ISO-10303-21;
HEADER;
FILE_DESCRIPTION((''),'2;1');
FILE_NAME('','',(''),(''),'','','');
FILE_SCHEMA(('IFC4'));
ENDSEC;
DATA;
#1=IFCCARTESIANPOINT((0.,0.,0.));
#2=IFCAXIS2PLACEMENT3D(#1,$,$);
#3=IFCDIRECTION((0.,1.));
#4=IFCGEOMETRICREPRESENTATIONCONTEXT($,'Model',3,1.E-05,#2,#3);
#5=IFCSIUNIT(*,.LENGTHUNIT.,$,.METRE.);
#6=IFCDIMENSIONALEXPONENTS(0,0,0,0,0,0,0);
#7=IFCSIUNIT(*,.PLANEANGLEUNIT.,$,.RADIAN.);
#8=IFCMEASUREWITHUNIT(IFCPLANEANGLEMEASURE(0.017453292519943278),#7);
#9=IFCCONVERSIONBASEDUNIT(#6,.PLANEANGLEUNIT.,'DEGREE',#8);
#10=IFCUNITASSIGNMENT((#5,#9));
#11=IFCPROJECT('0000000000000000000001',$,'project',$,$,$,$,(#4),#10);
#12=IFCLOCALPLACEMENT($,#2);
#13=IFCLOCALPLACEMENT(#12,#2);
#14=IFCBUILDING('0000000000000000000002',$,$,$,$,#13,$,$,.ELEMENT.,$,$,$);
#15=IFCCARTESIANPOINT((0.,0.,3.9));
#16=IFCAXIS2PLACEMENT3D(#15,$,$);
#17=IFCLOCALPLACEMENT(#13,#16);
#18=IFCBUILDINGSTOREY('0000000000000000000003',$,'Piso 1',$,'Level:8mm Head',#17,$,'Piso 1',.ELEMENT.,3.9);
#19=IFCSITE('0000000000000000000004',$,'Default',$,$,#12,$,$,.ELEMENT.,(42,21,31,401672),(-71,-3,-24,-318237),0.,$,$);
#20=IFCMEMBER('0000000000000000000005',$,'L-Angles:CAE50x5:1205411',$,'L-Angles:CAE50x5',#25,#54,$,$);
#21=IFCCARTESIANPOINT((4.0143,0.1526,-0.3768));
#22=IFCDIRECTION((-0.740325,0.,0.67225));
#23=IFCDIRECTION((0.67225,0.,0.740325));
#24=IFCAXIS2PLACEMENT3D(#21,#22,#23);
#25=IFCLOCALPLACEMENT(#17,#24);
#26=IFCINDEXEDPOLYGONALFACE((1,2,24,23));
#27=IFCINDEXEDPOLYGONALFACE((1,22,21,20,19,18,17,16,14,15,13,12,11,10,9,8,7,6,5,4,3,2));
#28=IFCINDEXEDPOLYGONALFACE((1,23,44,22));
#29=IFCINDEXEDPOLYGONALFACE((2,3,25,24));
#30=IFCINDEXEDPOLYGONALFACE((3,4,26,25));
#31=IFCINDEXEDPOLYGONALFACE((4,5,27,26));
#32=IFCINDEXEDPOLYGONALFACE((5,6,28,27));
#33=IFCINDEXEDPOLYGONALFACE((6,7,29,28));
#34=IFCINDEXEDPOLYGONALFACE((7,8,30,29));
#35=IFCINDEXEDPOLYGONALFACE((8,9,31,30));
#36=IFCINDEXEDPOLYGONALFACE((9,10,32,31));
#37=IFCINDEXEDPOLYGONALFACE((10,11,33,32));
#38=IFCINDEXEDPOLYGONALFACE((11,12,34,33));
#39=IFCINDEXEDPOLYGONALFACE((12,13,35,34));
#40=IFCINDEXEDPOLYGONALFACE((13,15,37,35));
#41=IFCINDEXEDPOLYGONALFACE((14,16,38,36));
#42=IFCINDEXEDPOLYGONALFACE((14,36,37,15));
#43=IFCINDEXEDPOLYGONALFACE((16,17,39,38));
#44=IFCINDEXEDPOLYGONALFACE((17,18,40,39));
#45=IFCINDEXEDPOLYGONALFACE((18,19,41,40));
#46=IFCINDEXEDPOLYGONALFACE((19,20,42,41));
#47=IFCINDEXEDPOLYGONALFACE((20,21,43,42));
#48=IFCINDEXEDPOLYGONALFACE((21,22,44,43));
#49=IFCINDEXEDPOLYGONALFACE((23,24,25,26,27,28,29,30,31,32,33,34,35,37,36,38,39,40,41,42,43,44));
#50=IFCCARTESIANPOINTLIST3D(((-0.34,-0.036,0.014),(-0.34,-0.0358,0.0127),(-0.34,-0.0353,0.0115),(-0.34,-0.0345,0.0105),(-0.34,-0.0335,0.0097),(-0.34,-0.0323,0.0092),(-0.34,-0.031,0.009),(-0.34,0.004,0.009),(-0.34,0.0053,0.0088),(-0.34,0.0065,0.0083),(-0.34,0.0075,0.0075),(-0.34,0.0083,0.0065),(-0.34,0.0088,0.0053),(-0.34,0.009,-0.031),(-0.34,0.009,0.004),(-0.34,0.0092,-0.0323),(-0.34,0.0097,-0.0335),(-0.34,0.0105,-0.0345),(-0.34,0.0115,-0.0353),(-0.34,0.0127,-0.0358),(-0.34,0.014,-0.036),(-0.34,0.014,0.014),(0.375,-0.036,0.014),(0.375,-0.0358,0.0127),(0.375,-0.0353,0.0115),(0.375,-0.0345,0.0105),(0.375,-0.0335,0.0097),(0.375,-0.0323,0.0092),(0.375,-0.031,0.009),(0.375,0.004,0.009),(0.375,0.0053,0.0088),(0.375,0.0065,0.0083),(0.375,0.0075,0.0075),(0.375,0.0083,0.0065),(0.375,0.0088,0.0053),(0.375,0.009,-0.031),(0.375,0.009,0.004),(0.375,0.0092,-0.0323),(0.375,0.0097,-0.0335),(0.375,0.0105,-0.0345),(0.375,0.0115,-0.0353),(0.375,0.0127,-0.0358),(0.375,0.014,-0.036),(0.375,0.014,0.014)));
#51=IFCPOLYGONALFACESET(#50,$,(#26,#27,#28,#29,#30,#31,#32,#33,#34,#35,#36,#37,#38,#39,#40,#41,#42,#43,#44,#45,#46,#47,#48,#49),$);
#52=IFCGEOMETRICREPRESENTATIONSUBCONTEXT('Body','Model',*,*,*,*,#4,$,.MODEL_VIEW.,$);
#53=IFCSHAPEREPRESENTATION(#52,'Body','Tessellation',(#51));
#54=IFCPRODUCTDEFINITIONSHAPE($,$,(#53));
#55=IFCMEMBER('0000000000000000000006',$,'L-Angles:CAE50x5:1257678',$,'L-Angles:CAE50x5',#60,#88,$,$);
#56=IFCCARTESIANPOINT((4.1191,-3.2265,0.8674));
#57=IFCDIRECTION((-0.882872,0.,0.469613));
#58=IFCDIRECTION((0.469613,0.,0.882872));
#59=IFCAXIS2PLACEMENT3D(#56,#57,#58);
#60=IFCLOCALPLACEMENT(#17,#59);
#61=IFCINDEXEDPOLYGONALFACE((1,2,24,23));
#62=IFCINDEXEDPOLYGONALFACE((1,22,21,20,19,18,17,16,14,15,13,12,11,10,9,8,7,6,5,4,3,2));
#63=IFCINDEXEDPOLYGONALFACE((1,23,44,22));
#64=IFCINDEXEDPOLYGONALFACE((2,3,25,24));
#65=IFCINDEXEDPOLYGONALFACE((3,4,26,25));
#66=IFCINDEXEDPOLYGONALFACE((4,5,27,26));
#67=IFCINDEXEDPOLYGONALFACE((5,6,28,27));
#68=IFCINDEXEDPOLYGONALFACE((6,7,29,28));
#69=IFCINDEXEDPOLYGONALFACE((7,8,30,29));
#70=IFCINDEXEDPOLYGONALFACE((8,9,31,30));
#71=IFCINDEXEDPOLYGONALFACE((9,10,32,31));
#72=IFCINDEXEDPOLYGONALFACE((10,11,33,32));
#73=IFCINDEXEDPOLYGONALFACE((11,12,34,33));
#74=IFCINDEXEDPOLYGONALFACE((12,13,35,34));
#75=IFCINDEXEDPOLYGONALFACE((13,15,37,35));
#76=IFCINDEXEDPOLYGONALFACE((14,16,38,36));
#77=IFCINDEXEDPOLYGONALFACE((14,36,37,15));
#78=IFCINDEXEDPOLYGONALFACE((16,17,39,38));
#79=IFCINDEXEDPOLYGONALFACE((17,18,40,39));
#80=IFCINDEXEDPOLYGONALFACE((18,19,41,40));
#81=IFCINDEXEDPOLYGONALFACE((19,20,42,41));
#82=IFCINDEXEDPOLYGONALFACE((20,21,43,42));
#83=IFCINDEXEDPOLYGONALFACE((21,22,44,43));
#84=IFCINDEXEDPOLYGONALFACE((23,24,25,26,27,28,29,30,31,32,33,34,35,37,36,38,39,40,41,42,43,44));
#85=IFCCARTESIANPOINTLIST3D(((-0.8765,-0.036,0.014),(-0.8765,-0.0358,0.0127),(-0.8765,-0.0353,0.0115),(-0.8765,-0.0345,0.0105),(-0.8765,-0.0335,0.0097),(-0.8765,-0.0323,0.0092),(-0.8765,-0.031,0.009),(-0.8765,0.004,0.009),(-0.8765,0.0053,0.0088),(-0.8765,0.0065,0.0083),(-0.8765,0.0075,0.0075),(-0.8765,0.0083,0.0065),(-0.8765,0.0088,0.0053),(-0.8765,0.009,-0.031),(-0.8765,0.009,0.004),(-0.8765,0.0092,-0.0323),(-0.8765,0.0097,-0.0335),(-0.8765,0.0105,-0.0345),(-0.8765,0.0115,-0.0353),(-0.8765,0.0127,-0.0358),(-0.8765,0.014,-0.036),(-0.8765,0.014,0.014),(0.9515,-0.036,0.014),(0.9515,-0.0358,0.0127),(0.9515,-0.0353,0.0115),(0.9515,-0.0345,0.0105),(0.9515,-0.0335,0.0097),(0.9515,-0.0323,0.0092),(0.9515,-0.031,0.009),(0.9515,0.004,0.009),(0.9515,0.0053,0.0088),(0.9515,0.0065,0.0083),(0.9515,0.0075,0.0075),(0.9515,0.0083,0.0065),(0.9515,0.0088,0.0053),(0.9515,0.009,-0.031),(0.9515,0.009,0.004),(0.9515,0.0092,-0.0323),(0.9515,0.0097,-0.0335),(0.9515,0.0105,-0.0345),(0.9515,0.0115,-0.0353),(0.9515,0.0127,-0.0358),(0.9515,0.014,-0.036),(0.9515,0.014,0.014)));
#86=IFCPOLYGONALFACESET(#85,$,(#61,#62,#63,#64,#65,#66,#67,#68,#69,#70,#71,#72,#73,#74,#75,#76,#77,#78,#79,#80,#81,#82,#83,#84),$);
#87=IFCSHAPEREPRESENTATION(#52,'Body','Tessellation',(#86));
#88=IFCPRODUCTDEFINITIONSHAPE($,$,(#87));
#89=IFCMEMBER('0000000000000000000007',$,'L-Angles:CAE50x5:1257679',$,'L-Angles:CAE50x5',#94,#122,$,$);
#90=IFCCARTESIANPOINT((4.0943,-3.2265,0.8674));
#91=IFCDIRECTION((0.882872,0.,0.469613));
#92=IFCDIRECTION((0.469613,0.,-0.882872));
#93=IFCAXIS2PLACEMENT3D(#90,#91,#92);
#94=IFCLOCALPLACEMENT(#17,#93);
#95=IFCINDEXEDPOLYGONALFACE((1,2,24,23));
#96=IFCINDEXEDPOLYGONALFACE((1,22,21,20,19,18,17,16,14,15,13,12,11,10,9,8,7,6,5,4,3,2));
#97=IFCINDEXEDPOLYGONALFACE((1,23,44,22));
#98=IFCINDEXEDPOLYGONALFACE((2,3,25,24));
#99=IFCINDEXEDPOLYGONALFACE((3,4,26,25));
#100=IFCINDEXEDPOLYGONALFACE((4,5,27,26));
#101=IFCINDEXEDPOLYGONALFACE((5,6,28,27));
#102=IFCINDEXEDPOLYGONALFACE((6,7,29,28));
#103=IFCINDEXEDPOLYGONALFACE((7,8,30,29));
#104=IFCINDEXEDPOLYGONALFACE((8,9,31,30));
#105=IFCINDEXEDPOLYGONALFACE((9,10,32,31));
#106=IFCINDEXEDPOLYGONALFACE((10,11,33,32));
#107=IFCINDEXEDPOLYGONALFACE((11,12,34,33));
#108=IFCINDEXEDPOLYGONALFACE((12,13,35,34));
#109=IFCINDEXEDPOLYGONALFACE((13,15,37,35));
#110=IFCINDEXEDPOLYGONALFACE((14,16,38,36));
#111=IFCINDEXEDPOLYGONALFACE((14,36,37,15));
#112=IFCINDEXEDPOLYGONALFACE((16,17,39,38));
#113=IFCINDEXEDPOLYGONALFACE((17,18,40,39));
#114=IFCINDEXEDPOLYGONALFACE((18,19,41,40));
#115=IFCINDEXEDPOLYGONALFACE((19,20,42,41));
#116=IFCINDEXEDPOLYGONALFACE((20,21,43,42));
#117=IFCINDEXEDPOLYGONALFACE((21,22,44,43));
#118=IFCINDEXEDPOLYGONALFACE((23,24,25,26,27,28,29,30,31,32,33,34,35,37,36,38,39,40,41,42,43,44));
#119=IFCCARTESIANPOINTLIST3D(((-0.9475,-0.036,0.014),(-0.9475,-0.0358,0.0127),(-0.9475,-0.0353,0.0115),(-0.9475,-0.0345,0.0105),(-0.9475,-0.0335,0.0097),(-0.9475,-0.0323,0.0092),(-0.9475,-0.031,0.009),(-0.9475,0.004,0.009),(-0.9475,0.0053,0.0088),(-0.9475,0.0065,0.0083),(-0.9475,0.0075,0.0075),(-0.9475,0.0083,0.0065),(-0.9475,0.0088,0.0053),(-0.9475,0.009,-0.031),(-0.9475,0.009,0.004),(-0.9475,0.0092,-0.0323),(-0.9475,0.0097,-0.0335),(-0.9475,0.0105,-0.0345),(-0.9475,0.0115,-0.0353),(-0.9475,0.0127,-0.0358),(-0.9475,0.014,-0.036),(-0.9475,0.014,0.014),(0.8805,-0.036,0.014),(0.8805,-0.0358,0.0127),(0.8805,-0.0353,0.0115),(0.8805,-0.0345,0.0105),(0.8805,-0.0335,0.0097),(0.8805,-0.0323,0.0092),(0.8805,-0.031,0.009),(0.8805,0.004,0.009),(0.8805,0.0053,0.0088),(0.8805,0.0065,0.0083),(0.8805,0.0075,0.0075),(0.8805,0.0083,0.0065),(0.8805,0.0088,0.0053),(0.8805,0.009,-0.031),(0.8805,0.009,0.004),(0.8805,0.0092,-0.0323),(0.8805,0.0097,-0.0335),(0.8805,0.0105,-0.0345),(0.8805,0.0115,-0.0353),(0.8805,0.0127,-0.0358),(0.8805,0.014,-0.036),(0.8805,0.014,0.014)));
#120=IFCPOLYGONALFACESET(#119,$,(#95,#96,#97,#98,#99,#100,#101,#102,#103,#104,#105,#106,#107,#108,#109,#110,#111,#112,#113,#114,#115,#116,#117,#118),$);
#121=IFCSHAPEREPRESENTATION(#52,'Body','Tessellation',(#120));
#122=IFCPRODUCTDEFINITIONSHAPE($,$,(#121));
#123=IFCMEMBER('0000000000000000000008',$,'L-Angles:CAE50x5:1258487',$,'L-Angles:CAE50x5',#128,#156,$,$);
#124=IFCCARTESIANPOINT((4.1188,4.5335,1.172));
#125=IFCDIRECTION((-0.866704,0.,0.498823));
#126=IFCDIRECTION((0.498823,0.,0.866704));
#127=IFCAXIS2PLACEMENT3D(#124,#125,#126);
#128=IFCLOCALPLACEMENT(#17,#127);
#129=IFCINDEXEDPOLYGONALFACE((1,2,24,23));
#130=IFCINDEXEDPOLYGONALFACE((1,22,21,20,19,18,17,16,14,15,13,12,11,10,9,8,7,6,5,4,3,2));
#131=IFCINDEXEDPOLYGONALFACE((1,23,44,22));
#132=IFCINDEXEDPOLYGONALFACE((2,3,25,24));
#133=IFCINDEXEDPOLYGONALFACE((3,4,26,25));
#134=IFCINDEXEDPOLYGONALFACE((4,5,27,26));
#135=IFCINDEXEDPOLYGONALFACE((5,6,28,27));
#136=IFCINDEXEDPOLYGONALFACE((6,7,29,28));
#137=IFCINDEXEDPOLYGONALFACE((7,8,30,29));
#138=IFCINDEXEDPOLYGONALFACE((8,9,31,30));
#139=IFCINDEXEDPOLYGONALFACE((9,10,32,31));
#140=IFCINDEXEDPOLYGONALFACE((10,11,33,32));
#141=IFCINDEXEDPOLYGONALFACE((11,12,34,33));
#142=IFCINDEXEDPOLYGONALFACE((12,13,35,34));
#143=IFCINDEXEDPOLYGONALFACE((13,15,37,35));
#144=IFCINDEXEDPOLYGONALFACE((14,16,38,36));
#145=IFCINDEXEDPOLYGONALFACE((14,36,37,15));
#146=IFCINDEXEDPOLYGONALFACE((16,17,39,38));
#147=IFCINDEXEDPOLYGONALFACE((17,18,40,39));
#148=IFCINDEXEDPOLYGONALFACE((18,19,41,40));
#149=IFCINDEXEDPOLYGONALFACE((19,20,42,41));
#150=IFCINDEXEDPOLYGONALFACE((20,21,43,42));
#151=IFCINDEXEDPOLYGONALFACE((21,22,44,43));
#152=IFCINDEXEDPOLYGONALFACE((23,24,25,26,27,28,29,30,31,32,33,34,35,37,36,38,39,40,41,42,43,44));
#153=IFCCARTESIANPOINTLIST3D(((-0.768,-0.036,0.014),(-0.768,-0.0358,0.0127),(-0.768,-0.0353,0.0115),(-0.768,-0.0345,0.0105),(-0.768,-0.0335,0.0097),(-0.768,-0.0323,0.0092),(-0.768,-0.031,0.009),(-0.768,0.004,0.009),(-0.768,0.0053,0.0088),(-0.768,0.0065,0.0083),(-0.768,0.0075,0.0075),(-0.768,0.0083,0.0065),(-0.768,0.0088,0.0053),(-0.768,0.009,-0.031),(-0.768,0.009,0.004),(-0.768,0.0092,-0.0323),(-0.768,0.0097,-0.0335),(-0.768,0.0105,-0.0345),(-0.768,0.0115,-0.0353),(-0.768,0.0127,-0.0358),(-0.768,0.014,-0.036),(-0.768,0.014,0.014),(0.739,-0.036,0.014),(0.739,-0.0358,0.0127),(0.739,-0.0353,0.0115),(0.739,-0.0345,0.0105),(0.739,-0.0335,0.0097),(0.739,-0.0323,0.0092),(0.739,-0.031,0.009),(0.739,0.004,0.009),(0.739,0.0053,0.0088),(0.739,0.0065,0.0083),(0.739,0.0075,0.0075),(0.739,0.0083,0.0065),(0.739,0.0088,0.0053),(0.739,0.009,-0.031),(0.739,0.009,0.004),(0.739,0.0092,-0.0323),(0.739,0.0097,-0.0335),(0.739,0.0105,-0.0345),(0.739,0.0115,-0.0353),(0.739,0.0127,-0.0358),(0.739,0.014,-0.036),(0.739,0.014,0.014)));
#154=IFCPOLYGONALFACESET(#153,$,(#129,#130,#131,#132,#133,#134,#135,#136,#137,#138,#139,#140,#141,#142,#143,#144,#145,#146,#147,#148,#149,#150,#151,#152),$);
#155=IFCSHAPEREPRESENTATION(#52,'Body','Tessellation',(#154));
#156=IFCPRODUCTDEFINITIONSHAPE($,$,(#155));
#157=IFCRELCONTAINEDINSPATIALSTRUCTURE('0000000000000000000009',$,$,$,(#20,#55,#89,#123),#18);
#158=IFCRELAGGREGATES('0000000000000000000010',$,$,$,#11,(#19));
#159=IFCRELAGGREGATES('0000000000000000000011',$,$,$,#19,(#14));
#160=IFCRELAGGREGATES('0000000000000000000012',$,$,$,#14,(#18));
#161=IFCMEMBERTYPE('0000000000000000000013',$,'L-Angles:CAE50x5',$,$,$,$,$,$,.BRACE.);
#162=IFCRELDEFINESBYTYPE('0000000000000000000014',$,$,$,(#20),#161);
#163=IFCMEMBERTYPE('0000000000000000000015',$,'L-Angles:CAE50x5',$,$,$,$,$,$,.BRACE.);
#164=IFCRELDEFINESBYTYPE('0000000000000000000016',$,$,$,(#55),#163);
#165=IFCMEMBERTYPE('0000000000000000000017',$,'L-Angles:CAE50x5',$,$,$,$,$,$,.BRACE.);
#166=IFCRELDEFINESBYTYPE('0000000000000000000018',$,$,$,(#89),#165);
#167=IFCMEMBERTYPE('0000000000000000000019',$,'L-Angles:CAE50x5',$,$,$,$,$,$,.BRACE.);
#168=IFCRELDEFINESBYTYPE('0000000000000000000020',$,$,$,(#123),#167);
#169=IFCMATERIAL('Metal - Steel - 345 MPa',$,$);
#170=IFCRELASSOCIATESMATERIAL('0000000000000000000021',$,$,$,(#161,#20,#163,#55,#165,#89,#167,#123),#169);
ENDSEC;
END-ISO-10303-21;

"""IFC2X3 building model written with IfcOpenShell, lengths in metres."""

from ifc_helpers import new_model, entity, si_unit, converted_unit, direction, frame, frame_2d, origin, place, context, subcontext, project, spatial, polyline, circle_curve, parameter, trimmed, segment, composite_curve, outline, extrude, source, transform, mapped, material, type_object, type_shapes, element, save


model = new_model("IFC2X3")

# Units and contexts
model_context = context("Model", 3, precision=1e-05, world=origin(), true_north=direction((0.0, 1.0)))
body_context = subcontext(model_context, "Body", "Model", "MODEL_VIEW")
ifc_project = project(units=[si_unit("LENGTHUNIT", "METRE"), converted_unit("PLANEANGLEUNIT", "DEGREE", entity("IfcPlaneAngleMeasure", 0.017453292519943278), si_unit("PLANEANGLEUNIT", "RADIAN"), dimensions=[0, 0, 0, 0, 0, 0, 0])], contexts=[model_context])

# Site, building, storey
site_placement = place(None, origin())
site = spatial("IfcSite", under=ifc_project, at=site_placement, Name="Default", CompositionType="ELEMENT", RefLatitude=(42, 21, 31, 401672), RefLongitude=(-71, -3, -24, -318237), RefElevation=0.0)
building_placement = place(site_placement, origin())
building = spatial("IfcBuilding", under=site, at=building_placement, CompositionType="ELEMENT")
storey_placement = place(building_placement, frame((0.0, 0.0, 3.9)))
storey = spatial("IfcBuildingStorey", under=building, at=storey_placement, Name="Piso 1", ObjectType="Level:8mm Head", LongName="Piso 1", CompositionType="ELEMENT", Elevation=3.9)

# Shared definitions
ifc_material_1 = material(Name="Metal - Steel - 345 MPa")

# Member
member_type_1 = type_object("IfcMemberType", Name="L-Angles:CAE50x5", PredefinedType="BRACE", material=ifc_material_1)
shared_shape_1 = source(origin(), body_context, "Body", "SweptSolid", [
    extrude(outline(composite_curve([segment(polyline([(-0.0164, -0.0164), (0.0336, -0.0164)]), True, "CONTINUOUS"), segment(trimmed(circle_curve(frame_2d((0.0286, -0.0164), x_axis=(1.0, 0.0)), 0.005), [parameter(0.0)], [parameter(90.0)], True, "PARAMETER"), True, "CONTINUOUS"), segment(polyline([(0.0286, -0.0114), (-0.0064, -0.0114)]), True, "CONTINUOUS"), segment(trimmed(circle_curve(frame_2d((-0.0064, -0.0064), x_axis=(1.0, 0.0)), 0.005), [parameter(180.0)], [parameter(270.0)], True, "PARAMETER"), False, "CONTINUOUS"), segment(polyline([(-0.0114, -0.0064), (-0.0114, 0.0286)]), True, "CONTINUOUS"), segment(trimmed(circle_curve(frame_2d((-0.0164, 0.0286), x_axis=(1.0, 0.0)), 0.005), [parameter(0.0)], [parameter(90.0)], True, "PARAMETER"), True, "CONTINUOUS"), segment(polyline([(-0.0164, 0.0336), (-0.0164, -0.0164)]), True, "CONTINUOUS")], self_intersect=False)), frame((-0.34, -0.0024, -0.0024), z_axis=(1.0, 0.0, 0.0), x_axis=(0.0, -1.0, 0.0)), (0.0, 0.0, 1.0), 0.715),
])
type_shapes(member_type_1, [shared_shape_1])
member_1_placement = place(storey_placement, frame((4.0143, 0.1526, -0.3768), z_axis=(-0.740325, 0.0, 0.67225), x_axis=(0.67225, 0.0, 0.740325)))
element("IfcMember", 1, at=member_1_placement, inside=storey, type_object=member_type_1, material=ifc_material_1, Name="L-Angles:CAE50x5:1205411", ObjectType="L-Angles:CAE50x5", context=body_context, shape_type="MappedRepresentation", body=[
    mapped(shared_shape_1, transform((0.0, 0.0, 0.0), scale=1.0)),
])

# Members
member_type_2 = type_object("IfcMemberType", Name="L-Angles:CAE50x5", PredefinedType="BRACE", material=ifc_material_1)
shared_shape_2 = source(origin(), body_context, "Body", "SweptSolid", [
    extrude(outline(composite_curve([segment(polyline([(-0.0164, -0.0164), (0.0336, -0.0164)]), True, "CONTINUOUS"), segment(trimmed(circle_curve(frame_2d((0.0286, -0.0164), x_axis=(1.0, 0.0)), 0.005), [parameter(0.0)], [parameter(90.0)], True, "PARAMETER"), True, "CONTINUOUS"), segment(polyline([(0.0286, -0.0114), (-0.0064, -0.0114)]), True, "CONTINUOUS"), segment(trimmed(circle_curve(frame_2d((-0.0064, -0.0064), x_axis=(1.0, 0.0)), 0.005), [parameter(180.0)], [parameter(270.0)], True, "PARAMETER"), False, "CONTINUOUS"), segment(polyline([(-0.0114, -0.0064), (-0.0114, 0.0286)]), True, "CONTINUOUS"), segment(trimmed(circle_curve(frame_2d((-0.0164, 0.0286), x_axis=(1.0, 0.0)), 0.005), [parameter(0.0)], [parameter(90.0)], True, "PARAMETER"), True, "CONTINUOUS"), segment(polyline([(-0.0164, 0.0336), (-0.0164, -0.0164)]), True, "CONTINUOUS")], self_intersect=False)), frame((-0.8765, -0.0024, -0.0024), z_axis=(1.0, 0.0, 0.0), x_axis=(0.0, -1.0, 0.0)), (0.0, 0.0, 1.0), 1.828),
])
type_shapes(member_type_2, [shared_shape_2])
member_2_placement = place(storey_placement, frame((4.1191, -3.2265, 0.8674), z_axis=(-0.882872, 0.0, 0.469613), x_axis=(0.469613, 0.0, 0.882872)))
element("IfcMember", 2, at=member_2_placement, inside=storey, type_object=member_type_2, material=ifc_material_1, Name="L-Angles:CAE50x5:1257678", ObjectType="L-Angles:CAE50x5", context=body_context, shape_type="MappedRepresentation", body=[
    mapped(shared_shape_2, transform((0.0, 0.0, 0.0), scale=1.0)),
])
member_type_3 = type_object("IfcMemberType", Name="L-Angles:CAE50x5", PredefinedType="BRACE", material=ifc_material_1)
shared_shape_3 = source(origin(), body_context, "Body", "SweptSolid", [
    extrude(outline(composite_curve([segment(polyline([(-0.0164, -0.0164), (0.0336, -0.0164)]), True, "CONTINUOUS"), segment(trimmed(circle_curve(frame_2d((0.0286, -0.0164), x_axis=(1.0, 0.0)), 0.005), [parameter(0.0)], [parameter(90.0)], True, "PARAMETER"), True, "CONTINUOUS"), segment(polyline([(0.0286, -0.0114), (-0.0064, -0.0114)]), True, "CONTINUOUS"), segment(trimmed(circle_curve(frame_2d((-0.0064, -0.0064), x_axis=(1.0, 0.0)), 0.005), [parameter(180.0)], [parameter(270.0)], True, "PARAMETER"), False, "CONTINUOUS"), segment(polyline([(-0.0114, -0.0064), (-0.0114, 0.0286)]), True, "CONTINUOUS"), segment(trimmed(circle_curve(frame_2d((-0.0164, 0.0286), x_axis=(1.0, 0.0)), 0.005), [parameter(0.0)], [parameter(90.0)], True, "PARAMETER"), True, "CONTINUOUS"), segment(polyline([(-0.0164, 0.0336), (-0.0164, -0.0164)]), True, "CONTINUOUS")], self_intersect=False)), frame((-0.9475, -0.0024, -0.0024), z_axis=(1.0, 0.0, 0.0), x_axis=(0.0, -1.0, 0.0)), (0.0, 0.0, 1.0), 1.828),
])
type_shapes(member_type_3, [shared_shape_3])
member_3_placement = place(storey_placement, frame((4.0943, -3.2265, 0.8674), z_axis=(0.882872, 0.0, 0.469613), x_axis=(0.469613, 0.0, -0.882872)))
element("IfcMember", 3, at=member_3_placement, inside=storey, type_object=member_type_3, material=ifc_material_1, Name="L-Angles:CAE50x5:1257679", ObjectType="L-Angles:CAE50x5", context=body_context, shape_type="MappedRepresentation", body=[
    mapped(shared_shape_3, transform((0.0, 0.0, 0.0), scale=1.0)),
])
member_type_4 = type_object("IfcMemberType", Name="L-Angles:CAE50x5", PredefinedType="BRACE", material=ifc_material_1)
shared_shape_4 = source(origin(), body_context, "Body", "SweptSolid", [
    extrude(outline(composite_curve([segment(polyline([(-0.0164, -0.0164), (0.0336, -0.0164)]), True, "CONTINUOUS"), segment(trimmed(circle_curve(frame_2d((0.0286, -0.0164), x_axis=(1.0, 0.0)), 0.005), [parameter(0.0)], [parameter(90.0)], True, "PARAMETER"), True, "CONTINUOUS"), segment(polyline([(0.0286, -0.0114), (-0.0064, -0.0114)]), True, "CONTINUOUS"), segment(trimmed(circle_curve(frame_2d((-0.0064, -0.0064), x_axis=(1.0, 0.0)), 0.005), [parameter(180.0)], [parameter(270.0)], True, "PARAMETER"), False, "CONTINUOUS"), segment(polyline([(-0.0114, -0.0064), (-0.0114, 0.0286)]), True, "CONTINUOUS"), segment(trimmed(circle_curve(frame_2d((-0.0164, 0.0286), x_axis=(1.0, 0.0)), 0.005), [parameter(0.0)], [parameter(90.0)], True, "PARAMETER"), True, "CONTINUOUS"), segment(polyline([(-0.0164, 0.0336), (-0.0164, -0.0164)]), True, "CONTINUOUS")], self_intersect=False)), frame((-0.768, -0.0024, -0.0024), z_axis=(1.0, 0.0, 0.0), x_axis=(0.0, -1.0, 0.0)), (0.0, 0.0, 1.0), 1.507),
])
type_shapes(member_type_4, [shared_shape_4])
member_4_placement = place(storey_placement, frame((4.1188, 4.5335, 1.172), z_axis=(-0.866704, 0.0, 0.498823), x_axis=(0.498823, 0.0, 0.866704)))
element("IfcMember", 4, at=member_4_placement, inside=storey, type_object=member_type_4, material=ifc_material_1, Name="L-Angles:CAE50x5:1258487", ObjectType="L-Angles:CAE50x5", context=body_context, shape_type="MappedRepresentation", body=[
    mapped(shared_shape_4, transform((0.0, 0.0, 0.0), scale=1.0)),
])

save(model, "model.ifc")
